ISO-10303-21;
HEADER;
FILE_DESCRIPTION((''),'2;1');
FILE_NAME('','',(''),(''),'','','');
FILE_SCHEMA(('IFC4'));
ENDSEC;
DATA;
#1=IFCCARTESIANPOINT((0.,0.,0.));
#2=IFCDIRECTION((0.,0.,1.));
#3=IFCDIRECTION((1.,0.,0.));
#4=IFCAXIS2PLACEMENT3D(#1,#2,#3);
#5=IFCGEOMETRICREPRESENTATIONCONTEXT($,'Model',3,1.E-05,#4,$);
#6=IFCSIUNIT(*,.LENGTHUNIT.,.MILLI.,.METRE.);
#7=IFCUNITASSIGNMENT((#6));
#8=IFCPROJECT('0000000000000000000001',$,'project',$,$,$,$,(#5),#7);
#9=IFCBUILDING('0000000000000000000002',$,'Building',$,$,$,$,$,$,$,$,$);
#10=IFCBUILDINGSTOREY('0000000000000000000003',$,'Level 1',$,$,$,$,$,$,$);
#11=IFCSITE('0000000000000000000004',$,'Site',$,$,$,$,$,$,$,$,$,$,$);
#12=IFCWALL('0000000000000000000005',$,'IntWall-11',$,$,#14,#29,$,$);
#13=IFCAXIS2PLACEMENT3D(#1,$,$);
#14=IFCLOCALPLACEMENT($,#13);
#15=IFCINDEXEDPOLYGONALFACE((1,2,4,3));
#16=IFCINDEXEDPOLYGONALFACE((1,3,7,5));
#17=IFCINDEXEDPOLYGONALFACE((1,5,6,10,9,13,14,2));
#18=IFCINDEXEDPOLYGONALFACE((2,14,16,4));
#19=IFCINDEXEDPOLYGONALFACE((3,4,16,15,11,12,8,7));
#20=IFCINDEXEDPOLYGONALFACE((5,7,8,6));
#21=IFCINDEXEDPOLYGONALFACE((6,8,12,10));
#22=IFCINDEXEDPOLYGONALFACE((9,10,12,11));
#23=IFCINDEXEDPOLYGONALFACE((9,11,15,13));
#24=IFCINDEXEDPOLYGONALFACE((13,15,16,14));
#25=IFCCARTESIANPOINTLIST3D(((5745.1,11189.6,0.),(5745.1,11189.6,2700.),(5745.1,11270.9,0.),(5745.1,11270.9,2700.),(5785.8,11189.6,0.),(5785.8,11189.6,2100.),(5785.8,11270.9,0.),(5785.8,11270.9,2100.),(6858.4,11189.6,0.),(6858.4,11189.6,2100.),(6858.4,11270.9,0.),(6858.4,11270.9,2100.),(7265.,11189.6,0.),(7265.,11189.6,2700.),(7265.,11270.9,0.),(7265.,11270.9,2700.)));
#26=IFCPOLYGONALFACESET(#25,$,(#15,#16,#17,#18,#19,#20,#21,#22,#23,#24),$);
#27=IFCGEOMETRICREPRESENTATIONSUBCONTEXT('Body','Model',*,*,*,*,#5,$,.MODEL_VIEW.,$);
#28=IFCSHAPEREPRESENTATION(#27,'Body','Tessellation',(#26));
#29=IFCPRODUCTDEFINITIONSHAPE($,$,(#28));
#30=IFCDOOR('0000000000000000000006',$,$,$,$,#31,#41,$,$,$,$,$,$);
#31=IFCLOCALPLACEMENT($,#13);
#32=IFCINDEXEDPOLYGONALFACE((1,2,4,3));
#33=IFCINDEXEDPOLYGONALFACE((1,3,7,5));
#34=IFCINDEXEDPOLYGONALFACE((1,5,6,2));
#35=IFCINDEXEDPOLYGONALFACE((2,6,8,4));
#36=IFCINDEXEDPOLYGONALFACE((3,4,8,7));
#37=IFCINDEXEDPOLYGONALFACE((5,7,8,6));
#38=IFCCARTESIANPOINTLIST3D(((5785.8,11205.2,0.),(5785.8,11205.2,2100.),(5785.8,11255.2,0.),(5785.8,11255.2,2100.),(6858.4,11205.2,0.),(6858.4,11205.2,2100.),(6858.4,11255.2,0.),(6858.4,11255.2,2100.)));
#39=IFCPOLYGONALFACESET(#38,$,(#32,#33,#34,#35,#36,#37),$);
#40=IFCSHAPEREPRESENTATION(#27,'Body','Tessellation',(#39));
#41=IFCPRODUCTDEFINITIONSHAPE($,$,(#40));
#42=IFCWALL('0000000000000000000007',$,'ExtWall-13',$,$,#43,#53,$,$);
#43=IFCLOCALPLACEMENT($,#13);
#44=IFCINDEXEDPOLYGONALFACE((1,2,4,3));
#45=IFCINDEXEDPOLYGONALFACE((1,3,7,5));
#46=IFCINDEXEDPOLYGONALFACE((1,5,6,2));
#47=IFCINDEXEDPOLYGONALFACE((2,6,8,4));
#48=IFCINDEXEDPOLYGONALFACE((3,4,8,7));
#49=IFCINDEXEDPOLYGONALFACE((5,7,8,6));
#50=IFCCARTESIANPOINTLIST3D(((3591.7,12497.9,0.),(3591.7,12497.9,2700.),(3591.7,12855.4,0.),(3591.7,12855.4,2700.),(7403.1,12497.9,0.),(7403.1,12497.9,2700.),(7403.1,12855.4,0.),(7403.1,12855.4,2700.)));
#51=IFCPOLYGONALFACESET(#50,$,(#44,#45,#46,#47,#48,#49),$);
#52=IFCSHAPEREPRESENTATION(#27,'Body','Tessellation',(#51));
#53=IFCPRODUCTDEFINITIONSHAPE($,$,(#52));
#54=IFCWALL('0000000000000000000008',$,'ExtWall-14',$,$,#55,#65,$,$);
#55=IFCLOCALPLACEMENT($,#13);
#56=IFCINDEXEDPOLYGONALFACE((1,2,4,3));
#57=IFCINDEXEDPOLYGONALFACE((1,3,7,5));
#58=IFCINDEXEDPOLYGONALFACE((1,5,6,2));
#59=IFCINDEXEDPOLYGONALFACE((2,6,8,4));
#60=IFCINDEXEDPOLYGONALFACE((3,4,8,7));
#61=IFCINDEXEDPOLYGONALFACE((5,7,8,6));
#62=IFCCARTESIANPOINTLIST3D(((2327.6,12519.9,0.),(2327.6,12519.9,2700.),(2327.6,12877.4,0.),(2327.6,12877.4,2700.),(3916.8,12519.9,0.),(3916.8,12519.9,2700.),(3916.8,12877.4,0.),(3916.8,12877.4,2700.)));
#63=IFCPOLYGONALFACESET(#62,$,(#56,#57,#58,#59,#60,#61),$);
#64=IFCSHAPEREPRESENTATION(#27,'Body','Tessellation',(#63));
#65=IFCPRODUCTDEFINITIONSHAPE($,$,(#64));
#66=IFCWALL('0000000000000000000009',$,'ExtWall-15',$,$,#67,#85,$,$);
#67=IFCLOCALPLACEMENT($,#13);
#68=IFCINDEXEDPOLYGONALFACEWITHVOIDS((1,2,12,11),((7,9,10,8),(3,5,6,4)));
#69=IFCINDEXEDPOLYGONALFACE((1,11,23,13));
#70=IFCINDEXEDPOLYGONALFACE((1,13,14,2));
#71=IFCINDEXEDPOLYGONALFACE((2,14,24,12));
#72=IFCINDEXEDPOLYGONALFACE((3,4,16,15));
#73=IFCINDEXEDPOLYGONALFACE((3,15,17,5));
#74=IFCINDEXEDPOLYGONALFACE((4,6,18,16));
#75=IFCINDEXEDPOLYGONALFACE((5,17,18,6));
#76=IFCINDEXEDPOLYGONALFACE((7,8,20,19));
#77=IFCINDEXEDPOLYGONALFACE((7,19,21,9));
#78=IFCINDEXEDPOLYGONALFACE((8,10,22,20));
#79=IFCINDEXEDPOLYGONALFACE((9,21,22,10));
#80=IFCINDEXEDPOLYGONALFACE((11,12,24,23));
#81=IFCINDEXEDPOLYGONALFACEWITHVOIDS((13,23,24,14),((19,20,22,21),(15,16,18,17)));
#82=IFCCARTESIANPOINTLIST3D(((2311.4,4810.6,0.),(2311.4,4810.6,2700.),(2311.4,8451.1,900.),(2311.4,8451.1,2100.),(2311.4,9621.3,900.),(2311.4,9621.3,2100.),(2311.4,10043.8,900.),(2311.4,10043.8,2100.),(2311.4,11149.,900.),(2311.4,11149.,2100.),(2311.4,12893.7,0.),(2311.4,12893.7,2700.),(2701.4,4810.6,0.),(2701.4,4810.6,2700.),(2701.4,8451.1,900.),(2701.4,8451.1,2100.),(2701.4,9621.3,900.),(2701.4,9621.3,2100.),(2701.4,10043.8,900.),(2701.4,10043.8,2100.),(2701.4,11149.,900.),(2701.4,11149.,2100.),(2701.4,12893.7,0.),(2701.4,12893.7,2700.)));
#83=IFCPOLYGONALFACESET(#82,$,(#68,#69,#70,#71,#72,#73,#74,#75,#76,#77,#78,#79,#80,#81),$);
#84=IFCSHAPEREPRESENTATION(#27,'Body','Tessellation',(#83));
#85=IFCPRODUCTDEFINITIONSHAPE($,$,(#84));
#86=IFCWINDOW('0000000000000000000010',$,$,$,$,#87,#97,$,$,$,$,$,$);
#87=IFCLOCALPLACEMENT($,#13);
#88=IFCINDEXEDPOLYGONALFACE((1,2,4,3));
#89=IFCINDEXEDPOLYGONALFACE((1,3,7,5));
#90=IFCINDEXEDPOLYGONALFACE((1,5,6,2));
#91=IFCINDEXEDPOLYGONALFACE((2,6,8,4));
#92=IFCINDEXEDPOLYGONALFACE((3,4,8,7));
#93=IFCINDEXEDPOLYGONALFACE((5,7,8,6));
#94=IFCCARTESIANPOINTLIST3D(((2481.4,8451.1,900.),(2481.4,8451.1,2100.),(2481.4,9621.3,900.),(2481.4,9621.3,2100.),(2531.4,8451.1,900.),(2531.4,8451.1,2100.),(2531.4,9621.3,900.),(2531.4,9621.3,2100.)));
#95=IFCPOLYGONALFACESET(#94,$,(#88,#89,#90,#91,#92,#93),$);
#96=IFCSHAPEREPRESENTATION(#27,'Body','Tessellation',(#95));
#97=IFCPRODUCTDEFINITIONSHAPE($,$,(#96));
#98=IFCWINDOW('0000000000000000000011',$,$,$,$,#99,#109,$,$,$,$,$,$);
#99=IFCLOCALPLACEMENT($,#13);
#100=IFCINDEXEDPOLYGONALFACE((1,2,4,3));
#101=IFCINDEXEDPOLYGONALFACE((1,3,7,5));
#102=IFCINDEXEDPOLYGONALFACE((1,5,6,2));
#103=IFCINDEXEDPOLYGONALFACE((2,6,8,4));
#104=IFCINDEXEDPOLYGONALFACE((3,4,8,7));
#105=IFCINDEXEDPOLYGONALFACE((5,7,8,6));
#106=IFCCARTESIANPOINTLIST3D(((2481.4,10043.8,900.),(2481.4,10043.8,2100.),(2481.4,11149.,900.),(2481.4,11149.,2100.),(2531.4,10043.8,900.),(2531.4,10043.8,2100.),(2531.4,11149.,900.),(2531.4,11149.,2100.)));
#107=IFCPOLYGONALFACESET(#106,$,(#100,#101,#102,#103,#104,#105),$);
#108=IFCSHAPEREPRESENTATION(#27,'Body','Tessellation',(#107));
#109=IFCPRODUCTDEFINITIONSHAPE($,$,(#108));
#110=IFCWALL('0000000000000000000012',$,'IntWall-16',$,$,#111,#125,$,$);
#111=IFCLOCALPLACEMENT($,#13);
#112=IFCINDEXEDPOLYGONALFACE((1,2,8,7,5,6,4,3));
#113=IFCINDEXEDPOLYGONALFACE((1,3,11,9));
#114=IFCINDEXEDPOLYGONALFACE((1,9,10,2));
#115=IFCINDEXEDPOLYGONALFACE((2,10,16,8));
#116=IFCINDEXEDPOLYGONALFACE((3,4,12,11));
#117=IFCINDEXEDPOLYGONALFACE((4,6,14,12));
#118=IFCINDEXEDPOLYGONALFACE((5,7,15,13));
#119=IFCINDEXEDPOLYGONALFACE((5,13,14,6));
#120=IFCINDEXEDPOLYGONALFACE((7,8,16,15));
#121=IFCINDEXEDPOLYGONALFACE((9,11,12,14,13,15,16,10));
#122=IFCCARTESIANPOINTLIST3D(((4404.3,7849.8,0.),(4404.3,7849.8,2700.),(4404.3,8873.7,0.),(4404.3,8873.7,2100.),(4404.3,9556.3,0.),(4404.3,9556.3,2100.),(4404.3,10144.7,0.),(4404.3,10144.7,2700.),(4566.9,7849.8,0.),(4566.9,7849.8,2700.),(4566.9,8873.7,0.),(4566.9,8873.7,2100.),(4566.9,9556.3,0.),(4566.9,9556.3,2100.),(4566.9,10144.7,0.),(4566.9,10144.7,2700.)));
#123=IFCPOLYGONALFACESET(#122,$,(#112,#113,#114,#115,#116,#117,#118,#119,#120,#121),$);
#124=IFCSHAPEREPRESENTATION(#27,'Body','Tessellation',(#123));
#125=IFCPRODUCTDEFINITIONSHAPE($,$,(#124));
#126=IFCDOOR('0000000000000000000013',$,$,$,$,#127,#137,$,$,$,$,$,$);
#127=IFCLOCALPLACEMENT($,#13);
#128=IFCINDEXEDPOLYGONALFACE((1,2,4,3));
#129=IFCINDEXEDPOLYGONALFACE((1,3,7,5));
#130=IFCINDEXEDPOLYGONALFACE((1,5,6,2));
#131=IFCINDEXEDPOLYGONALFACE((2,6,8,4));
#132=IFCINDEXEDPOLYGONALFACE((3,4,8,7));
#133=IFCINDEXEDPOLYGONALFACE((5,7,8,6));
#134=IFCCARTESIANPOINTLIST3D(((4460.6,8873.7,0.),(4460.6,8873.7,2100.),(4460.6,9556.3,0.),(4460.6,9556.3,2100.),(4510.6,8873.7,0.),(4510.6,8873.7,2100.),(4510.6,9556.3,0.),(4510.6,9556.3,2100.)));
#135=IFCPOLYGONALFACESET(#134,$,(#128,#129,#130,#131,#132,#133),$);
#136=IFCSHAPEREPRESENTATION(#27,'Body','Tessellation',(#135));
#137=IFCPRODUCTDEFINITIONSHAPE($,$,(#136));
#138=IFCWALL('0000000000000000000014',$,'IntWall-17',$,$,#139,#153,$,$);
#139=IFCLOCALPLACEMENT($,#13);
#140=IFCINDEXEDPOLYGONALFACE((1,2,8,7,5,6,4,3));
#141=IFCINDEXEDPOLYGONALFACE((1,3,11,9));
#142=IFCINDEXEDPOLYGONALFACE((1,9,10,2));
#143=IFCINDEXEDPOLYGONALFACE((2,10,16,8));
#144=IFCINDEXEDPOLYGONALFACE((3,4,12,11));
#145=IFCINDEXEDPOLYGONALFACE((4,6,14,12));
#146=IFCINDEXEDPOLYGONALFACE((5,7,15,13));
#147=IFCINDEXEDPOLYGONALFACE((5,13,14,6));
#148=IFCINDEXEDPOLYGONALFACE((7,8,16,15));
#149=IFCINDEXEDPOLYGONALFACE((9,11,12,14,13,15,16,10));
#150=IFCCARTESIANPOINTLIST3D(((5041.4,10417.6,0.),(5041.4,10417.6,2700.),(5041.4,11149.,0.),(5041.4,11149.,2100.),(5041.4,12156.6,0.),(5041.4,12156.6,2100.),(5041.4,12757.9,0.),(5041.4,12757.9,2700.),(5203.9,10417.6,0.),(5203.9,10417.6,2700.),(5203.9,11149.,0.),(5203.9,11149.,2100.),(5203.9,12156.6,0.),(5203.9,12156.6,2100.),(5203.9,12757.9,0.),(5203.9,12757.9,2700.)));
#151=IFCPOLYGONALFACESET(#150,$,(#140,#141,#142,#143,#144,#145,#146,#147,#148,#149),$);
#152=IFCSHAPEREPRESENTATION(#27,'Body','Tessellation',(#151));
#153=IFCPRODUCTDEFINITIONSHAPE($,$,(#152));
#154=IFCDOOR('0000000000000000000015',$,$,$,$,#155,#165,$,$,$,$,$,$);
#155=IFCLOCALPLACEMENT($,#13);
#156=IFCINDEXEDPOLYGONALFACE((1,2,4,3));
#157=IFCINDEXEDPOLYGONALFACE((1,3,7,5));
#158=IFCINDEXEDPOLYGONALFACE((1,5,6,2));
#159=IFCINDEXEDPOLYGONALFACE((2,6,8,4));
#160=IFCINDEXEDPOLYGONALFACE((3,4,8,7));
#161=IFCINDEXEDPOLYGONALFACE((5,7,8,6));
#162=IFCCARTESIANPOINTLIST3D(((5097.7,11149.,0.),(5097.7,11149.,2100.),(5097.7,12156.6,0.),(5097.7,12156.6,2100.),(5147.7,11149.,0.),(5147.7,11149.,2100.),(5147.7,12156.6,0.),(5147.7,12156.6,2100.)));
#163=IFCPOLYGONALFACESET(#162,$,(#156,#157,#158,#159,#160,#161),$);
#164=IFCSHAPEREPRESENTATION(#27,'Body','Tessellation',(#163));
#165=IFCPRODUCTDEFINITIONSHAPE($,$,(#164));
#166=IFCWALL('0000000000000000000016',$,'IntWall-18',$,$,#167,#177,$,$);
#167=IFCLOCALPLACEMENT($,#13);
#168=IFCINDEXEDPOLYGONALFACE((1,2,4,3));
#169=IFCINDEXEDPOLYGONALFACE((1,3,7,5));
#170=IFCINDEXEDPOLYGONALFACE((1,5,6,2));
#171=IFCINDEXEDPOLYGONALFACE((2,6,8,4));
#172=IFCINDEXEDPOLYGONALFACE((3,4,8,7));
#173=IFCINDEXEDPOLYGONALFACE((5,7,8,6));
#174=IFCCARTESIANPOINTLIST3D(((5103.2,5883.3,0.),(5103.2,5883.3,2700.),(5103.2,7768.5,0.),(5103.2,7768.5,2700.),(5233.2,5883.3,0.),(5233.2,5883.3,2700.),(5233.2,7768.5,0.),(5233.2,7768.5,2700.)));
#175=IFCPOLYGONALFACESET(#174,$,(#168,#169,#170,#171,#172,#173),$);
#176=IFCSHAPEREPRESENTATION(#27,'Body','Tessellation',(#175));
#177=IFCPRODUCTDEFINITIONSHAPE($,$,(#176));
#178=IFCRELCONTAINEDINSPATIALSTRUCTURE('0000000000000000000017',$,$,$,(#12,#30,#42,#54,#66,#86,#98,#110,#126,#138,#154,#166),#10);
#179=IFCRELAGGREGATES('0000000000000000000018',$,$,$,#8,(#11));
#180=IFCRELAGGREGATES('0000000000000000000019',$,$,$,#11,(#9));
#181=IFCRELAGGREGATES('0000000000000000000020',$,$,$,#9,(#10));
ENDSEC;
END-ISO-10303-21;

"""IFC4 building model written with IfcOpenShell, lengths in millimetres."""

from ifc_helpers import new_model, si_unit, frame, origin_with_axes, place, context, subcontext, project, spatial, indexed_curve, outline, extrude, element, fill, save


model = new_model("IFC4")

# Units and contexts
model_context = context("Model", 3, precision=1e-05, world=origin_with_axes())
body_context = subcontext(model_context, "Body", "Model", "MODEL_VIEW")
ifc_project = project(units=[si_unit("LENGTHUNIT", "METRE", prefix="MILLI")], contexts=[model_context])

# Site, building, storey
site = spatial("IfcSite", under=ifc_project, Name="Site")
building = spatial("IfcBuilding", under=site, Name="Building")
storey = spatial("IfcBuildingStorey", under=building, Name="Level 1")

# Wall, opening, door
wall_1_placement = place(None, frame((5745.1, 11230.2, 0.0), z_axis=(0.0, 0.0, 1.0), x_axis=(1.0, 0.0, 0.0)))
wall_1 = element("IfcWall", 1, at=wall_1_placement, inside=storey, Name="IntWall-11", context=body_context, shape_type="SweptSolid", body=[
    extrude(outline(indexed_curve([(0.0, 0.0), (0.0, 81.3), (1519.9, 81.3), (1519.9, 0.0), (0.0, 0.0)], self_intersect=False)), frame((0.0, -40.6, 0.0), z_axis=(0.0, 0.0, 1.0), x_axis=(1.0, 0.0, 0.0)), (0.0, 0.0, 1.0), 2700.0),
])
opening_1_placement = place(wall_1_placement, frame((40.6, 0.0, 0.0), z_axis=(0.0, 0.0, 1.0), x_axis=(1.0, 0.0, 0.0)))
opening_1 = element("IfcOpeningElement", 2, at=opening_1_placement, cuts=wall_1, context=body_context, shape_type="SweptSolid", body=[
    extrude(outline(indexed_curve([(0.0, 0.0), (0.0, 181.3), (1072.6, 181.3), (1072.6, 0.0), (0.0, 0.0)], self_intersect=False)), frame((0.0, -90.6, 0.0), z_axis=(0.0, 0.0, 1.0), x_axis=(1.0, 0.0, 0.0)), (0.0, 0.0, 1.0), 2100.0),
])
door_1_placement = place(opening_1_placement, origin_with_axes())
door_1 = element("IfcDoor", 3, at=door_1_placement, inside=storey, context=body_context, shape_type="SweptSolid", body=[
    extrude(outline(indexed_curve([(0.0, 0.0), (0.0, 50.0), (1072.6, 50.0), (1072.6, 0.0), (0.0, 0.0)], self_intersect=False)), frame((0.0, -25.0, 0.0), z_axis=(0.0, 0.0, 1.0), x_axis=(1.0, 0.0, 0.0)), (0.0, 0.0, 1.0), 2100.0),
])
fill(opening_1, door_1)

# Walls
wall_2_placement = place(None, frame((3591.7, 12676.7, 0.0), z_axis=(0.0, 0.0, 1.0), x_axis=(1.0, 0.0, 0.0)))
element("IfcWall", 4, at=wall_2_placement, inside=storey, Name="ExtWall-13", context=body_context, shape_type="SweptSolid", body=[
    extrude(outline(indexed_curve([(0.0, 0.0), (0.0, 357.5), (3811.4, 357.5), (3811.4, 0.0), (0.0, 0.0)], self_intersect=False)), frame((0.0, -178.8, 0.0), z_axis=(0.0, 0.0, 1.0), x_axis=(1.0, 0.0, 0.0)), (0.0, 0.0, 1.0), 2700.0),
])
wall_3_placement = place(None, frame((2327.6, 12698.7, 0.0), z_axis=(0.0, 0.0, 1.0), x_axis=(1.0, 0.0, 0.0)))
element("IfcWall", 5, at=wall_3_placement, inside=storey, Name="ExtWall-14", context=body_context, shape_type="SweptSolid", body=[
    extrude(outline(indexed_curve([(0.0, 0.0), (0.0, 357.5), (1589.1, 357.5), (1589.1, 0.0), (0.0, 0.0)], self_intersect=False)), frame((0.0, -178.8, 0.0), z_axis=(0.0, 0.0, 1.0), x_axis=(1.0, 0.0, 0.0)), (0.0, 0.0, 1.0), 2700.0),
])

# Wall, openings, windows
wall_4_placement = place(None, frame((2506.4, 4810.6, 0.0), z_axis=(0.0, 0.0, 1.0), x_axis=(0.0, 1.0, 0.0)))
wall_4 = element("IfcWall", 6, at=wall_4_placement, inside=storey, Name="ExtWall-15", context=body_context, shape_type="SweptSolid", body=[
    extrude(outline(indexed_curve([(0.0, 0.0), (0.0, 390.1), (8083.1, 390.1), (8083.1, 0.0), (0.0, 0.0)], self_intersect=False)), frame((0.0, -195.0, 0.0), z_axis=(0.0, 0.0, 1.0), x_axis=(1.0, 0.0, 0.0)), (0.0, 0.0, 1.0), 2700.0),
])
opening_2_placement = place(wall_4_placement, frame((3640.5, 0.0, 900.0), z_axis=(0.0, 0.0, 1.0), x_axis=(1.0, 0.0, 0.0)))
opening_2 = element("IfcOpeningElement", 7, at=opening_2_placement, cuts=wall_4, context=body_context, shape_type="SweptSolid", body=[
    extrude(outline(indexed_curve([(0.0, 0.0), (0.0, 490.1), (1170.2, 490.1), (1170.2, 0.0), (0.0, 0.0)], self_intersect=False)), frame((0.0, -245.0, 0.0), z_axis=(0.0, 0.0, 1.0), x_axis=(1.0, 0.0, 0.0)), (0.0, 0.0, 1.0), 1200.0),
])
opening_3_placement = place(wall_4_placement, frame((5233.2, 0.0, 900.0), z_axis=(0.0, 0.0, 1.0), x_axis=(1.0, 0.0, 0.0)))
opening_3 = element("IfcOpeningElement", 8, at=opening_3_placement, cuts=wall_4, context=body_context, shape_type="SweptSolid", body=[
    extrude(outline(indexed_curve([(0.0, 0.0), (0.0, 490.1), (1105.1, 490.1), (1105.1, 0.0), (0.0, 0.0)], self_intersect=False)), frame((0.0, -245.0, 0.0), z_axis=(0.0, 0.0, 1.0), x_axis=(1.0, 0.0, 0.0)), (0.0, 0.0, 1.0), 1200.0),
])
window_1_placement = place(opening_2_placement, origin_with_axes())
window_1 = element("IfcWindow", 9, at=window_1_placement, inside=storey, context=body_context, shape_type="SweptSolid", body=[
    extrude(outline(indexed_curve([(0.0, 0.0), (0.0, 50.0), (1170.2, 50.0), (1170.2, 0.0), (0.0, 0.0)], self_intersect=False)), frame((0.0, -25.0, 0.0), z_axis=(0.0, 0.0, 1.0), x_axis=(1.0, 0.0, 0.0)), (0.0, 0.0, 1.0), 1200.0),
])
fill(opening_2, window_1)
window_2_placement = place(opening_3_placement, origin_with_axes())
window_2 = element("IfcWindow", 10, at=window_2_placement, inside=storey, context=body_context, shape_type="SweptSolid", body=[
    extrude(outline(indexed_curve([(0.0, 0.0), (0.0, 50.0), (1105.1, 50.0), (1105.1, 0.0), (0.0, 0.0)], self_intersect=False)), frame((0.0, -25.0, 0.0), z_axis=(0.0, 0.0, 1.0), x_axis=(1.0, 0.0, 0.0)), (0.0, 0.0, 1.0), 1200.0),
])
fill(opening_3, window_2)

# Walls, openings, doors
wall_5_placement = place(None, frame((4485.6, 7849.8, 0.0), z_axis=(0.0, 0.0, 1.0), x_axis=(0.0, 1.0, 0.0)))
wall_5 = element("IfcWall", 11, at=wall_5_placement, inside=storey, Name="IntWall-16", context=body_context, shape_type="SweptSolid", body=[
    extrude(outline(indexed_curve([(0.0, 0.0), (0.0, 162.5), (2294.9, 162.5), (2294.9, 0.0), (0.0, 0.0)], self_intersect=False)), frame((0.0, -81.3, 0.0), z_axis=(0.0, 0.0, 1.0), x_axis=(1.0, 0.0, 0.0)), (0.0, 0.0, 1.0), 2700.0),
])
opening_4_placement = place(wall_5_placement, frame((1023.9, 0.0, 0.0), z_axis=(0.0, 0.0, 1.0), x_axis=(1.0, 0.0, 0.0)))
opening_4 = element("IfcOpeningElement", 12, at=opening_4_placement, cuts=wall_5, context=body_context, shape_type="SweptSolid", body=[
    extrude(outline(indexed_curve([(0.0, 0.0), (0.0, 262.5), (682.6, 262.5), (682.6, 0.0), (0.0, 0.0)], self_intersect=False)), frame((0.0, -131.3, 0.0), z_axis=(0.0, 0.0, 1.0), x_axis=(1.0, 0.0, 0.0)), (0.0, 0.0, 1.0), 2100.0),
])
door_2_placement = place(opening_4_placement, origin_with_axes())
door_2 = element("IfcDoor", 13, at=door_2_placement, inside=storey, context=body_context, shape_type="SweptSolid", body=[
    extrude(outline(indexed_curve([(0.0, 0.0), (0.0, 50.0), (682.6, 50.0), (682.6, 0.0), (0.0, 0.0)], self_intersect=False)), frame((0.0, -25.0, 0.0), z_axis=(0.0, 0.0, 1.0), x_axis=(1.0, 0.0, 0.0)), (0.0, 0.0, 1.0), 2100.0),
])
fill(opening_4, door_2)
wall_6_placement = place(None, frame((5122.7, 10417.6, 0.0), z_axis=(0.0, 0.0, 1.0), x_axis=(0.0, 1.0, 0.0)))
wall_6 = element("IfcWall", 14, at=wall_6_placement, inside=storey, Name="IntWall-17", context=body_context, shape_type="SweptSolid", body=[
    extrude(outline(indexed_curve([(0.0, 0.0), (0.0, 162.5), (2340.3, 162.5), (2340.3, 0.0), (0.0, 0.0)], self_intersect=False)), frame((0.0, -81.3, 0.0), z_axis=(0.0, 0.0, 1.0), x_axis=(1.0, 0.0, 0.0)), (0.0, 0.0, 1.0), 2700.0),
])
opening_5_placement = place(wall_6_placement, frame((731.3, 0.0, 0.0), z_axis=(0.0, 0.0, 1.0), x_axis=(1.0, 0.0, 0.0)))
opening_5 = element("IfcOpeningElement", 15, at=opening_5_placement, cuts=wall_6, context=body_context, shape_type="SweptSolid", body=[
    extrude(outline(indexed_curve([(0.0, 0.0), (0.0, 262.5), (1007.6, 262.5), (1007.6, 0.0), (0.0, 0.0)], self_intersect=False)), frame((0.0, -131.3, 0.0), z_axis=(0.0, 0.0, 1.0), x_axis=(1.0, 0.0, 0.0)), (0.0, 0.0, 1.0), 2100.0),
])
door_3_placement = place(opening_5_placement, frame((0.0, 0.0, 0.0), z_axis=(0.0, 0.0, 1.0), x_axis=(1.0, 0.0, 0.0)))
door_3 = element("IfcDoor", 16, at=door_3_placement, inside=storey, context=body_context, shape_type="SweptSolid", body=[
    extrude(outline(indexed_curve([(0.0, 0.0), (0.0, 50.0), (1007.6, 50.0), (1007.6, 0.0), (0.0, 0.0)], self_intersect=False)), frame((0.0, -25.0, 0.0), z_axis=(0.0, 0.0, 1.0), x_axis=(1.0, 0.0, 0.0)), (0.0, 0.0, 1.0), 2100.0),
])
fill(opening_5, door_3)

# Wall
wall_7_placement = place(None, frame((5168.2, 5883.3, 0.0), z_axis=(0.0, 0.0, 1.0), x_axis=(0.0, 1.0, 0.0)))
element("IfcWall", 17, at=wall_7_placement, inside=storey, Name="IntWall-18", context=body_context, shape_type="SweptSolid", body=[
    extrude(outline(indexed_curve([(0.0, 0.0), (0.0, 130.0), (1885.2, 130.0), (1885.2, 0.0), (0.0, 0.0)], self_intersect=False)), frame((0.0, -65.0, 0.0), z_axis=(0.0, 0.0, 1.0), x_axis=(1.0, 0.0, 0.0)), (0.0, 0.0, 1.0), 2700.0),
])

save(model, "model.ifc")
